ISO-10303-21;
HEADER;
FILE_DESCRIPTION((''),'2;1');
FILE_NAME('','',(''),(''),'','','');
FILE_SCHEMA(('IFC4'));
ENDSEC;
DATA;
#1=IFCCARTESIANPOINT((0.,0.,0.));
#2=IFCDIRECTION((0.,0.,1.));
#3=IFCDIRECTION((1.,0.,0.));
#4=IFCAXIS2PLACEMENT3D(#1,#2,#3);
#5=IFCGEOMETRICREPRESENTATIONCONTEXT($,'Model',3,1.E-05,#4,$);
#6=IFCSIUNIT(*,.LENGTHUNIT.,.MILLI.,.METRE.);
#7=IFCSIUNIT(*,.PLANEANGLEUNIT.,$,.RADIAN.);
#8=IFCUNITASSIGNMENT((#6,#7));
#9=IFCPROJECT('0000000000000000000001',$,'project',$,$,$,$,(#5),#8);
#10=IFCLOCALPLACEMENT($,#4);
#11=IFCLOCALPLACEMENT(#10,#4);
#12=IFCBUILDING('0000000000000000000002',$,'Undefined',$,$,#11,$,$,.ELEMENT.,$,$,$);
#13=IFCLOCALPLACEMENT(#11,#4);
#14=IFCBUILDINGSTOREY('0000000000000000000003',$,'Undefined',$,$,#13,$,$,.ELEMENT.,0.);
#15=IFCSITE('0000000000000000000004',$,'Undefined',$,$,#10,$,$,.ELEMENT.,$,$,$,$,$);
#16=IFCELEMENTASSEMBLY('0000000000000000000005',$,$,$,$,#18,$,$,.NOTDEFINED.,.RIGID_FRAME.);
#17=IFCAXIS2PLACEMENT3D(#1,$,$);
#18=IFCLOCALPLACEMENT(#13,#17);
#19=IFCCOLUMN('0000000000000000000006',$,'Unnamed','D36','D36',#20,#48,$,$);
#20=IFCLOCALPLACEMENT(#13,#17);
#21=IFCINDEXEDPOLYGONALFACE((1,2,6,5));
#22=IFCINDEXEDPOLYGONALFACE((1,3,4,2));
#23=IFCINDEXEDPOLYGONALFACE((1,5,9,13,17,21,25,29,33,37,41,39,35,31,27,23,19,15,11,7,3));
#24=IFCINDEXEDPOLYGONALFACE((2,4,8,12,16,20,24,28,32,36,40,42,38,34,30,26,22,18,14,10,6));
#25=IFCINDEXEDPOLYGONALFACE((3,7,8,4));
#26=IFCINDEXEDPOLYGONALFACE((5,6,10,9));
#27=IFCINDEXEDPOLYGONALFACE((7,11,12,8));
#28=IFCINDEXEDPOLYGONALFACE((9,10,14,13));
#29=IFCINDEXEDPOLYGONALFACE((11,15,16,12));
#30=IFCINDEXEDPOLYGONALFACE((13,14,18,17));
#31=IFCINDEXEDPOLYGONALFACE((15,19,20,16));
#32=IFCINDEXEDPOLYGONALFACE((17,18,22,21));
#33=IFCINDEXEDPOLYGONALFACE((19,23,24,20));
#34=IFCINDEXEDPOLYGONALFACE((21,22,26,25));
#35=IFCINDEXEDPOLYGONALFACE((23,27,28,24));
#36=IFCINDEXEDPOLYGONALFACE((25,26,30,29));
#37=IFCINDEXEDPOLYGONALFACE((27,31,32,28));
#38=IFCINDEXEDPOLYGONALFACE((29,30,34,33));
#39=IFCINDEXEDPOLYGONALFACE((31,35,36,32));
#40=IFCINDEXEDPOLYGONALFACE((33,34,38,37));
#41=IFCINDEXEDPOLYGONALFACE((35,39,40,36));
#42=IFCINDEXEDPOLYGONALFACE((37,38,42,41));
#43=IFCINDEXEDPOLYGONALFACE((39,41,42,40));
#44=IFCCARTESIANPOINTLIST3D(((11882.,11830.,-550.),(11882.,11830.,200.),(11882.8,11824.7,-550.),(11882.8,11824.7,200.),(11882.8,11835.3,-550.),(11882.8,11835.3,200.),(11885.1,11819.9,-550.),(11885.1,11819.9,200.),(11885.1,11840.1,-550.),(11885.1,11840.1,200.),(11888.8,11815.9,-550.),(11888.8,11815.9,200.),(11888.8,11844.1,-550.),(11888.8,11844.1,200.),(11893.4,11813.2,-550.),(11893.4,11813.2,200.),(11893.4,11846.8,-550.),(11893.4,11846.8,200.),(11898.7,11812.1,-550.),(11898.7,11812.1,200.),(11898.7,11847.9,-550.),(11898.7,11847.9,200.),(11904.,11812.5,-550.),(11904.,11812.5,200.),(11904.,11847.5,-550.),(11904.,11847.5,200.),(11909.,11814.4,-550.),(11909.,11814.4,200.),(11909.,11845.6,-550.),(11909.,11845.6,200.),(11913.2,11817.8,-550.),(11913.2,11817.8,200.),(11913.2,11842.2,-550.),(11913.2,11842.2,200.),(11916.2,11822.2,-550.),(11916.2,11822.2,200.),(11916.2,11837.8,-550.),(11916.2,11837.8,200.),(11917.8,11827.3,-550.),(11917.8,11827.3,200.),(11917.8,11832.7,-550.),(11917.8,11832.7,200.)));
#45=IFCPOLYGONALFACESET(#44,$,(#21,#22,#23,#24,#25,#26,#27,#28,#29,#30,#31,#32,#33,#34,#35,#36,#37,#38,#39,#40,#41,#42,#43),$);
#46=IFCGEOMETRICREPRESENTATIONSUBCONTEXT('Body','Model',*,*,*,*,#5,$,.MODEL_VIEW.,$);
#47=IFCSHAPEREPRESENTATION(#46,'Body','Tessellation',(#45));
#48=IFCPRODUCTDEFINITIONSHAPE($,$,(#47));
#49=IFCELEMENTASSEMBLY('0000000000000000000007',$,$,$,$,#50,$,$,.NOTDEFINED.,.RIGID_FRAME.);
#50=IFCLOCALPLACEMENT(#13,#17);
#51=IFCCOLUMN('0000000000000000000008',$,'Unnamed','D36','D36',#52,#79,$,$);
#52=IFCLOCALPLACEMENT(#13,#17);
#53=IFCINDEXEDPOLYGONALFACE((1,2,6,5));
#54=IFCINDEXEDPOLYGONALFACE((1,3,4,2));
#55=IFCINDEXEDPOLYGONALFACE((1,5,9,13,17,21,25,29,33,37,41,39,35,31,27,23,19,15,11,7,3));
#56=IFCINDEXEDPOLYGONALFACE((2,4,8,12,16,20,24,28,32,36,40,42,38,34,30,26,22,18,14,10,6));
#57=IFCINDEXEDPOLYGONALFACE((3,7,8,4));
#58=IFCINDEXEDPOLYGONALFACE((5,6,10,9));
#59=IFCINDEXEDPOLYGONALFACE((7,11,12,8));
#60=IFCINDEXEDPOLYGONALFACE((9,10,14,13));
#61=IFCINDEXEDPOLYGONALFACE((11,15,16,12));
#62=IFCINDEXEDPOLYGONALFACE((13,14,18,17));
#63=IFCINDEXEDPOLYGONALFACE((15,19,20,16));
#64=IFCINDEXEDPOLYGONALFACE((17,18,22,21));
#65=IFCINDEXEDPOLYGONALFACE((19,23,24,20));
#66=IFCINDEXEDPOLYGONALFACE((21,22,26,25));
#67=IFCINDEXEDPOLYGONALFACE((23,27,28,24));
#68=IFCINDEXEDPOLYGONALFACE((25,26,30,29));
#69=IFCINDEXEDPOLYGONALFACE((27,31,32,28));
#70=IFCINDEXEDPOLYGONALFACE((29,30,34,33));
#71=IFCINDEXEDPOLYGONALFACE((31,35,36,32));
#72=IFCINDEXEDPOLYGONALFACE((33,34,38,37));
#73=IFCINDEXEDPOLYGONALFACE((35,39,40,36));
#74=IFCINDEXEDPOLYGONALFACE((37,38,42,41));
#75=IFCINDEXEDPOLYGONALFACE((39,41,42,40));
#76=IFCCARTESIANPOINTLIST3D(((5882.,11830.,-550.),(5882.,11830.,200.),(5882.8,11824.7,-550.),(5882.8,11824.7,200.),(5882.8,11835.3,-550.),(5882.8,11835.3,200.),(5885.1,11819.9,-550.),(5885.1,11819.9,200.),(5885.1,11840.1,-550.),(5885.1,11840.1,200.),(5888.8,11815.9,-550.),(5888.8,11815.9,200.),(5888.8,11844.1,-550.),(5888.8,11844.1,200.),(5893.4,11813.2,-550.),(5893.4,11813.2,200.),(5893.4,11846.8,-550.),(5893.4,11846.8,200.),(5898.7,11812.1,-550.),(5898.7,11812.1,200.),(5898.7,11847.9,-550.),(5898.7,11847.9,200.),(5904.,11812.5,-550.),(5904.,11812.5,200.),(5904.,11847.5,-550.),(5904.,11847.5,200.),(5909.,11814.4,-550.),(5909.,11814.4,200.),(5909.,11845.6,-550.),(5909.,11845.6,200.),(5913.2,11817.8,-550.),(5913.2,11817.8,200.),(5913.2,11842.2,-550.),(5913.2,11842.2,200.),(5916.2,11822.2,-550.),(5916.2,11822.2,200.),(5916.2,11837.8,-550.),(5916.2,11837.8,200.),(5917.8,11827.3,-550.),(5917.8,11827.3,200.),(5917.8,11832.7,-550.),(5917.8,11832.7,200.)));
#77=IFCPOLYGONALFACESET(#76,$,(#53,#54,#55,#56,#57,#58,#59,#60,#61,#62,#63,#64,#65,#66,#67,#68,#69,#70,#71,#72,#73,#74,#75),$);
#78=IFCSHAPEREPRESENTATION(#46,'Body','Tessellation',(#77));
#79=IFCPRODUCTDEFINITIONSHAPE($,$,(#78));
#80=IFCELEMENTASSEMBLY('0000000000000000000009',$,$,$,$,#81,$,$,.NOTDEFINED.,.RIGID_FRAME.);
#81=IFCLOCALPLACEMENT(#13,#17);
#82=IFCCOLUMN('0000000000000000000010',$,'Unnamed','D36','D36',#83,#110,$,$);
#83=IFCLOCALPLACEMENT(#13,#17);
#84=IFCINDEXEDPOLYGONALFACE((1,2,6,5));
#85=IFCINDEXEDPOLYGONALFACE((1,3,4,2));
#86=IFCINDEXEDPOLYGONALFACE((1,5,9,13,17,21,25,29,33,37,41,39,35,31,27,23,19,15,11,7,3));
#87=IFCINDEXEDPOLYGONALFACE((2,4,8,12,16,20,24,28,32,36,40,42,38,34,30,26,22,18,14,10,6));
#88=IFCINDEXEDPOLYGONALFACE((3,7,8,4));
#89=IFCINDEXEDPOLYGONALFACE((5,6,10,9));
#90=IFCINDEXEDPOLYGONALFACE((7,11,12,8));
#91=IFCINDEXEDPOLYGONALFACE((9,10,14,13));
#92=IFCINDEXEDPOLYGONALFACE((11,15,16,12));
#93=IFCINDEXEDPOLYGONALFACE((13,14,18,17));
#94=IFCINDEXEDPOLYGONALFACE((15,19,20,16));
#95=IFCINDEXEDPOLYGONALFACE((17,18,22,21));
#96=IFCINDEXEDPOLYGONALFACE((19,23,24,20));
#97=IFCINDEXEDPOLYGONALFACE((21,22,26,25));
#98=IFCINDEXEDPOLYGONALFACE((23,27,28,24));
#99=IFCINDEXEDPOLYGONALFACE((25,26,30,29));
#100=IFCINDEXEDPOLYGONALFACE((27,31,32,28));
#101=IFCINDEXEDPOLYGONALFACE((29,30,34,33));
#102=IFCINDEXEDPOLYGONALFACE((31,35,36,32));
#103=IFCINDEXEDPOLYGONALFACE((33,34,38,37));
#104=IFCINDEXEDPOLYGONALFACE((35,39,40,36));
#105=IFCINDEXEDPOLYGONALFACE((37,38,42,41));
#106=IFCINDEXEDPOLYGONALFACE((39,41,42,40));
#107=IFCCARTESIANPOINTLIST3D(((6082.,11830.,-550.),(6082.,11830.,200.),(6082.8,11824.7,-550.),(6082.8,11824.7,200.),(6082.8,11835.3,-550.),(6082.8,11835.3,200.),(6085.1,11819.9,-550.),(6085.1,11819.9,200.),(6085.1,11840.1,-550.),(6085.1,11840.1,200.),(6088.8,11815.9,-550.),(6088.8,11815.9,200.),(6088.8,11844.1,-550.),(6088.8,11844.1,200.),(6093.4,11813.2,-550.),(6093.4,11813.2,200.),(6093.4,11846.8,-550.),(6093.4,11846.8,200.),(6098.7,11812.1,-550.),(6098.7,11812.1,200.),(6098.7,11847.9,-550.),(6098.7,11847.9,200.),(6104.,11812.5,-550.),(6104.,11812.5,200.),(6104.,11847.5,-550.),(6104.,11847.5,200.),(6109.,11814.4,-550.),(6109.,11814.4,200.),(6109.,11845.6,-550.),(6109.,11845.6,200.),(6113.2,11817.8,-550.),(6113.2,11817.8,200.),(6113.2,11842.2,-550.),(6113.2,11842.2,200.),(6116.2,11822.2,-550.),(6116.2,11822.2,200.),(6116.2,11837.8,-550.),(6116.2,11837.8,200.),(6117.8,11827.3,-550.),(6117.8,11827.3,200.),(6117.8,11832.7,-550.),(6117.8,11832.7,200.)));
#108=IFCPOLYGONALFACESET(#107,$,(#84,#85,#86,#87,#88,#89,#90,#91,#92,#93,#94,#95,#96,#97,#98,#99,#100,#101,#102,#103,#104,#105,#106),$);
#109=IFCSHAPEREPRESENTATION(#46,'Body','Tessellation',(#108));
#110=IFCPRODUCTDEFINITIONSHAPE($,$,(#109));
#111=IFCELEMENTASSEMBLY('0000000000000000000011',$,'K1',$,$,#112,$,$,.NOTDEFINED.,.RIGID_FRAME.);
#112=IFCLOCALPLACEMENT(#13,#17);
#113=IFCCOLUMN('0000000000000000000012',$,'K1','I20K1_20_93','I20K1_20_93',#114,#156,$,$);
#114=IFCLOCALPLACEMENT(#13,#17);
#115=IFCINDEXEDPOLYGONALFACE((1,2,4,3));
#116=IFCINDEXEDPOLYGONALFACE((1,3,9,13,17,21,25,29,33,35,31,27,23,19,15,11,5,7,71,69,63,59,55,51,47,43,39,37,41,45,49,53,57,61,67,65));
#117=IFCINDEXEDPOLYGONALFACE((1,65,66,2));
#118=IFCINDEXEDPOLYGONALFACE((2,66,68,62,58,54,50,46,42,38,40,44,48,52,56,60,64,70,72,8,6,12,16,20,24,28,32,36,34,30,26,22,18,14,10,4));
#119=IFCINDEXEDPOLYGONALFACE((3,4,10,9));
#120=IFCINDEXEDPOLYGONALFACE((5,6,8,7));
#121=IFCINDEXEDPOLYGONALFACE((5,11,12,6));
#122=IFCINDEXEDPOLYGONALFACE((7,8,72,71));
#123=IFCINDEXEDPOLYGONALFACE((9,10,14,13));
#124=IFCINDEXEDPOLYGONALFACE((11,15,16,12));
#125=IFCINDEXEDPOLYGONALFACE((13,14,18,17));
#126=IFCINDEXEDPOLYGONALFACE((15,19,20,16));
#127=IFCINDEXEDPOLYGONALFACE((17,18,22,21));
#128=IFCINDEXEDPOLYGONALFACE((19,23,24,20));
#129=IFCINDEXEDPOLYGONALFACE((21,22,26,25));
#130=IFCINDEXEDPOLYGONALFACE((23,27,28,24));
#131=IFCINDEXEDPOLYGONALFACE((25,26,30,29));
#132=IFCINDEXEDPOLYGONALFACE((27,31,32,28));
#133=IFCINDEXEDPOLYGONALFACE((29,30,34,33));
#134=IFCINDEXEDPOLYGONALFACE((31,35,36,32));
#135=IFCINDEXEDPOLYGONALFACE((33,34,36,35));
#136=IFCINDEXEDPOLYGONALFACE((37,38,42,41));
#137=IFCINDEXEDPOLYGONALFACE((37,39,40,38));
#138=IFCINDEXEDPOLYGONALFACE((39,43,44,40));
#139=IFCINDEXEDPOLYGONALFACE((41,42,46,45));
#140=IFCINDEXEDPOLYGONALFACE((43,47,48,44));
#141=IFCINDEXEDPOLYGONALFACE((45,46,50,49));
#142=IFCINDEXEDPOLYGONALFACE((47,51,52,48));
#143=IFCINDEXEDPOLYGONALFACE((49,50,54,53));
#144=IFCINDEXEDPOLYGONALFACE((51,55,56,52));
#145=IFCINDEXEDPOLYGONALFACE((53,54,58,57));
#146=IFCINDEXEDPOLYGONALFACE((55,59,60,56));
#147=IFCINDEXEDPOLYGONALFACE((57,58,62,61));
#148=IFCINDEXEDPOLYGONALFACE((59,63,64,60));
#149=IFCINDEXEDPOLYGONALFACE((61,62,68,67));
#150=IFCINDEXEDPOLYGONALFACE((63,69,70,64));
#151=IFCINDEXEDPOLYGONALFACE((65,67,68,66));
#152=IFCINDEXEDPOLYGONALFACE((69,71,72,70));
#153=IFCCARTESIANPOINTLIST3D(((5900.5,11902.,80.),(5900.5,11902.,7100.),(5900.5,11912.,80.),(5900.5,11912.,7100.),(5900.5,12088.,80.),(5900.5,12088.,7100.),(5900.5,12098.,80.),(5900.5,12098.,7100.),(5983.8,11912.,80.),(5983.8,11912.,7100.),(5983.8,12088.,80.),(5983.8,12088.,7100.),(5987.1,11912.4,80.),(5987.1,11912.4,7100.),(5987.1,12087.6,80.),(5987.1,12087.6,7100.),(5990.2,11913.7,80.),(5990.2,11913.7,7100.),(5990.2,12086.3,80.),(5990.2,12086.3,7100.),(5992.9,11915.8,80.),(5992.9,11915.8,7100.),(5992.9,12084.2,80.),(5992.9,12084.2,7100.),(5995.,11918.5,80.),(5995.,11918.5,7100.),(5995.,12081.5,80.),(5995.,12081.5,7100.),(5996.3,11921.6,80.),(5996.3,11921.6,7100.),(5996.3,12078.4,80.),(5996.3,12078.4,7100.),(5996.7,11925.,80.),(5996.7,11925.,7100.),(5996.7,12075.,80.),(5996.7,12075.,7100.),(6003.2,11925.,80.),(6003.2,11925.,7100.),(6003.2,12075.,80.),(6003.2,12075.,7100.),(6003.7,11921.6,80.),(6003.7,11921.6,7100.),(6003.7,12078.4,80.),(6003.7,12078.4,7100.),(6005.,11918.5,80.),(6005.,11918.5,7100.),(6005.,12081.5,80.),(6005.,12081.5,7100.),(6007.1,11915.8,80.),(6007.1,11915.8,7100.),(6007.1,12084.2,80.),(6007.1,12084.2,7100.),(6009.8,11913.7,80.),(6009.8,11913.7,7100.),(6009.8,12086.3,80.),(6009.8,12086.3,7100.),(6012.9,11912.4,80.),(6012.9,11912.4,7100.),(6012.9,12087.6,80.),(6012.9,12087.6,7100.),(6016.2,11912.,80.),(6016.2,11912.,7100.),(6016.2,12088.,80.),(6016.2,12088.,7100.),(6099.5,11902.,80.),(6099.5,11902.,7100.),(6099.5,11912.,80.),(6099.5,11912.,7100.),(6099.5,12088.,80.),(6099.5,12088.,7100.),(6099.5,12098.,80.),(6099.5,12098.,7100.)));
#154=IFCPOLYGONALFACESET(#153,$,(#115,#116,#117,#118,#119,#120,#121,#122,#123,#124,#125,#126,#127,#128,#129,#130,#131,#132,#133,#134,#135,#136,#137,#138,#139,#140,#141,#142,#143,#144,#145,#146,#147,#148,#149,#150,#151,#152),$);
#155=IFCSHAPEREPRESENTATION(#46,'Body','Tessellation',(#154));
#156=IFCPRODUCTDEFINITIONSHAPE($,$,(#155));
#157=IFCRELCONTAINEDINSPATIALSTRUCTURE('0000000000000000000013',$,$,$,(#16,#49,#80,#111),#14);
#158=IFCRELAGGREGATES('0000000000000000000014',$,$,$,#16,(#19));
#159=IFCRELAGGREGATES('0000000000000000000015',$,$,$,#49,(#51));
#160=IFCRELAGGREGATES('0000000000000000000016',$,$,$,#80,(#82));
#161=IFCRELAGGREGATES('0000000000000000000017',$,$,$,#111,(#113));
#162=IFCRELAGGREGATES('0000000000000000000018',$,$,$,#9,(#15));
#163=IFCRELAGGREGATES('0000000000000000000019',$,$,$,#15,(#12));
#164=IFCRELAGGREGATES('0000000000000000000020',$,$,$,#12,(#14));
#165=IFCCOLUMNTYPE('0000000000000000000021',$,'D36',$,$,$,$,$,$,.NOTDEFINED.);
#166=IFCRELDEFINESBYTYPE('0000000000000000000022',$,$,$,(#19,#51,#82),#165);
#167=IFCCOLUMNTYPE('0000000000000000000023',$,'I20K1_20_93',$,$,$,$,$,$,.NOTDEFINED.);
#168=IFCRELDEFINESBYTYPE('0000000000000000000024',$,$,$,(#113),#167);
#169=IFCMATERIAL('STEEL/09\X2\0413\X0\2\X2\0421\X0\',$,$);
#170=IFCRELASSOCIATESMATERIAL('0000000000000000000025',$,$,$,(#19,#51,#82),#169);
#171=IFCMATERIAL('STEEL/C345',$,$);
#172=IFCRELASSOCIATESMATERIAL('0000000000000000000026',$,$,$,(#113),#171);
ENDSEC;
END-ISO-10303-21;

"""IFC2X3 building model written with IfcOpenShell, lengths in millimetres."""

from ifc_helpers import new_model, si_unit, frame, origin_with_axes, origin_2d_with_axis, place, context, subcontext, project, spatial, circle, i_section, extrude, material, type_object, element, aggregate, save


model = new_model("IFC2X3")

# Units and contexts
model_context = context("Model", 3, precision=1e-05, world=origin_with_axes())
body_context = subcontext(model_context, "Body", "Model", "MODEL_VIEW")
ifc_project = project(units=[si_unit("LENGTHUNIT", "METRE", prefix="MILLI"), si_unit("PLANEANGLEUNIT", "RADIAN")], contexts=[model_context])

# Site, building, storey
site_placement = place(None, origin_with_axes())
site = spatial("IfcSite", under=ifc_project, at=site_placement, Name="Undefined", CompositionType="ELEMENT")
building_placement = place(site_placement, origin_with_axes())
building = spatial("IfcBuilding", under=site, at=building_placement, Name="Undefined", CompositionType="ELEMENT")
storey_placement = place(building_placement, origin_with_axes())
storey = spatial("IfcBuildingStorey", under=building, at=storey_placement, Name="Undefined", CompositionType="ELEMENT", Elevation=0.0)

# Element assemblies, columns
assembly_1_placement = place(storey_placement, origin_with_axes())
assembly_1 = element("IfcElementAssembly", 1, at=assembly_1_placement, inside=storey, AssemblyPlace="NOTDEFINED", PredefinedType="RIGID_FRAME")
ifc_material_1 = material(Name="STEEL/09Г2С")
column_type_1 = type_object("IfcColumnType", Name="D36", PredefinedType="NOTDEFINED")
column_1_placement = place(assembly_1_placement, frame((11900.0, 11830.0, -550.0), z_axis=(0.0, 0.0, 1.0), x_axis=(0.0, 1.0, 0.0)))
column_1 = element("IfcColumn", 2, at=column_1_placement, type_object=column_type_1, material=ifc_material_1, Name="Unnamed", Description="D36", ObjectType="D36", context=body_context, shape_type="SweptSolid", body=[
    extrude(circle(Radius=18.0, at=origin_2d_with_axis()), frame((0.0, 0.0, 750.0), z_axis=(0.0, 0.0, -1.0), x_axis=(0.0, 1.0, 0.0)), (0.0, 0.0, 1.0), 750.0),
])
aggregate(assembly_1, [column_1])
assembly_2_placement = place(storey_placement, origin_with_axes())
assembly_2 = element("IfcElementAssembly", 3, at=assembly_2_placement, inside=storey, AssemblyPlace="NOTDEFINED", PredefinedType="RIGID_FRAME")
column_2_placement = place(assembly_2_placement, frame((5900.0, 11830.0, -550.0), z_axis=(0.0, 0.0, 1.0), x_axis=(0.0, 1.0, 0.0)))
column_2 = element("IfcColumn", 4, at=column_2_placement, type_object=column_type_1, material=ifc_material_1, Name="Unnamed", Description="D36", ObjectType="D36", context=body_context, shape_type="SweptSolid", body=[
    extrude(circle(Radius=18.0, at=origin_2d_with_axis()), frame((0.0, 0.0, 750.0), z_axis=(0.0, 0.0, -1.0), x_axis=(0.0, 1.0, 0.0)), (0.0, 0.0, 1.0), 750.0),
])
aggregate(assembly_2, [column_2])
assembly_3_placement = place(storey_placement, origin_with_axes())
assembly_3 = element("IfcElementAssembly", 5, at=assembly_3_placement, inside=storey, AssemblyPlace="NOTDEFINED", PredefinedType="RIGID_FRAME")
column_3_placement = place(assembly_3_placement, frame((6100.0, 11830.0, -550.0), z_axis=(0.0, 0.0, 1.0), x_axis=(0.0, 1.0, 0.0)))
column_3 = element("IfcColumn", 6, at=column_3_placement, type_object=column_type_1, material=ifc_material_1, Name="Unnamed", Description="D36", ObjectType="D36", context=body_context, shape_type="SweptSolid", body=[
    extrude(circle(Radius=18.0, at=origin_2d_with_axis()), frame((0.0, 0.0, 750.0), z_axis=(0.0, 0.0, -1.0), x_axis=(0.0, 1.0, 0.0)), (0.0, 0.0, 1.0), 750.0),
])
aggregate(assembly_3, [column_3])
assembly_4_placement = place(storey_placement, origin_with_axes())
assembly_4 = element("IfcElementAssembly", 7, at=assembly_4_placement, inside=storey, Name="K1", AssemblyPlace="NOTDEFINED", PredefinedType="RIGID_FRAME")
ifc_material_2 = material(Name="STEEL/C345")
column_type_2 = type_object("IfcColumnType", Name="I20K1_20_93", PredefinedType="NOTDEFINED")
column_4_placement = place(assembly_4_placement, frame((6000.0, 12000.0, 80.0), z_axis=(0.0, 0.0, 1.0), x_axis=(0.0, 1.0, 0.0)))
column_4 = element("IfcColumn", 8, at=column_4_placement, type_object=column_type_2, material=ifc_material_2, Name="K1", Description="I20K1_20_93", ObjectType="I20K1_20_93", context=body_context, shape_type="SweptSolid", body=[
    extrude(i_section(OverallWidth=199.0, OverallDepth=196.0, WebThickness=6.5, FlangeThickness=10.0, FilletRadius=13.0, at=origin_2d_with_axis()), frame((0.0, 0.0, 7020.0), z_axis=(0.0, 0.0, -1.0), x_axis=(0.0, 1.0, 0.0)), (0.0, 0.0, 1.0), 7020.0),
])
aggregate(assembly_4, [column_4])

save(model, "model.ifc")
